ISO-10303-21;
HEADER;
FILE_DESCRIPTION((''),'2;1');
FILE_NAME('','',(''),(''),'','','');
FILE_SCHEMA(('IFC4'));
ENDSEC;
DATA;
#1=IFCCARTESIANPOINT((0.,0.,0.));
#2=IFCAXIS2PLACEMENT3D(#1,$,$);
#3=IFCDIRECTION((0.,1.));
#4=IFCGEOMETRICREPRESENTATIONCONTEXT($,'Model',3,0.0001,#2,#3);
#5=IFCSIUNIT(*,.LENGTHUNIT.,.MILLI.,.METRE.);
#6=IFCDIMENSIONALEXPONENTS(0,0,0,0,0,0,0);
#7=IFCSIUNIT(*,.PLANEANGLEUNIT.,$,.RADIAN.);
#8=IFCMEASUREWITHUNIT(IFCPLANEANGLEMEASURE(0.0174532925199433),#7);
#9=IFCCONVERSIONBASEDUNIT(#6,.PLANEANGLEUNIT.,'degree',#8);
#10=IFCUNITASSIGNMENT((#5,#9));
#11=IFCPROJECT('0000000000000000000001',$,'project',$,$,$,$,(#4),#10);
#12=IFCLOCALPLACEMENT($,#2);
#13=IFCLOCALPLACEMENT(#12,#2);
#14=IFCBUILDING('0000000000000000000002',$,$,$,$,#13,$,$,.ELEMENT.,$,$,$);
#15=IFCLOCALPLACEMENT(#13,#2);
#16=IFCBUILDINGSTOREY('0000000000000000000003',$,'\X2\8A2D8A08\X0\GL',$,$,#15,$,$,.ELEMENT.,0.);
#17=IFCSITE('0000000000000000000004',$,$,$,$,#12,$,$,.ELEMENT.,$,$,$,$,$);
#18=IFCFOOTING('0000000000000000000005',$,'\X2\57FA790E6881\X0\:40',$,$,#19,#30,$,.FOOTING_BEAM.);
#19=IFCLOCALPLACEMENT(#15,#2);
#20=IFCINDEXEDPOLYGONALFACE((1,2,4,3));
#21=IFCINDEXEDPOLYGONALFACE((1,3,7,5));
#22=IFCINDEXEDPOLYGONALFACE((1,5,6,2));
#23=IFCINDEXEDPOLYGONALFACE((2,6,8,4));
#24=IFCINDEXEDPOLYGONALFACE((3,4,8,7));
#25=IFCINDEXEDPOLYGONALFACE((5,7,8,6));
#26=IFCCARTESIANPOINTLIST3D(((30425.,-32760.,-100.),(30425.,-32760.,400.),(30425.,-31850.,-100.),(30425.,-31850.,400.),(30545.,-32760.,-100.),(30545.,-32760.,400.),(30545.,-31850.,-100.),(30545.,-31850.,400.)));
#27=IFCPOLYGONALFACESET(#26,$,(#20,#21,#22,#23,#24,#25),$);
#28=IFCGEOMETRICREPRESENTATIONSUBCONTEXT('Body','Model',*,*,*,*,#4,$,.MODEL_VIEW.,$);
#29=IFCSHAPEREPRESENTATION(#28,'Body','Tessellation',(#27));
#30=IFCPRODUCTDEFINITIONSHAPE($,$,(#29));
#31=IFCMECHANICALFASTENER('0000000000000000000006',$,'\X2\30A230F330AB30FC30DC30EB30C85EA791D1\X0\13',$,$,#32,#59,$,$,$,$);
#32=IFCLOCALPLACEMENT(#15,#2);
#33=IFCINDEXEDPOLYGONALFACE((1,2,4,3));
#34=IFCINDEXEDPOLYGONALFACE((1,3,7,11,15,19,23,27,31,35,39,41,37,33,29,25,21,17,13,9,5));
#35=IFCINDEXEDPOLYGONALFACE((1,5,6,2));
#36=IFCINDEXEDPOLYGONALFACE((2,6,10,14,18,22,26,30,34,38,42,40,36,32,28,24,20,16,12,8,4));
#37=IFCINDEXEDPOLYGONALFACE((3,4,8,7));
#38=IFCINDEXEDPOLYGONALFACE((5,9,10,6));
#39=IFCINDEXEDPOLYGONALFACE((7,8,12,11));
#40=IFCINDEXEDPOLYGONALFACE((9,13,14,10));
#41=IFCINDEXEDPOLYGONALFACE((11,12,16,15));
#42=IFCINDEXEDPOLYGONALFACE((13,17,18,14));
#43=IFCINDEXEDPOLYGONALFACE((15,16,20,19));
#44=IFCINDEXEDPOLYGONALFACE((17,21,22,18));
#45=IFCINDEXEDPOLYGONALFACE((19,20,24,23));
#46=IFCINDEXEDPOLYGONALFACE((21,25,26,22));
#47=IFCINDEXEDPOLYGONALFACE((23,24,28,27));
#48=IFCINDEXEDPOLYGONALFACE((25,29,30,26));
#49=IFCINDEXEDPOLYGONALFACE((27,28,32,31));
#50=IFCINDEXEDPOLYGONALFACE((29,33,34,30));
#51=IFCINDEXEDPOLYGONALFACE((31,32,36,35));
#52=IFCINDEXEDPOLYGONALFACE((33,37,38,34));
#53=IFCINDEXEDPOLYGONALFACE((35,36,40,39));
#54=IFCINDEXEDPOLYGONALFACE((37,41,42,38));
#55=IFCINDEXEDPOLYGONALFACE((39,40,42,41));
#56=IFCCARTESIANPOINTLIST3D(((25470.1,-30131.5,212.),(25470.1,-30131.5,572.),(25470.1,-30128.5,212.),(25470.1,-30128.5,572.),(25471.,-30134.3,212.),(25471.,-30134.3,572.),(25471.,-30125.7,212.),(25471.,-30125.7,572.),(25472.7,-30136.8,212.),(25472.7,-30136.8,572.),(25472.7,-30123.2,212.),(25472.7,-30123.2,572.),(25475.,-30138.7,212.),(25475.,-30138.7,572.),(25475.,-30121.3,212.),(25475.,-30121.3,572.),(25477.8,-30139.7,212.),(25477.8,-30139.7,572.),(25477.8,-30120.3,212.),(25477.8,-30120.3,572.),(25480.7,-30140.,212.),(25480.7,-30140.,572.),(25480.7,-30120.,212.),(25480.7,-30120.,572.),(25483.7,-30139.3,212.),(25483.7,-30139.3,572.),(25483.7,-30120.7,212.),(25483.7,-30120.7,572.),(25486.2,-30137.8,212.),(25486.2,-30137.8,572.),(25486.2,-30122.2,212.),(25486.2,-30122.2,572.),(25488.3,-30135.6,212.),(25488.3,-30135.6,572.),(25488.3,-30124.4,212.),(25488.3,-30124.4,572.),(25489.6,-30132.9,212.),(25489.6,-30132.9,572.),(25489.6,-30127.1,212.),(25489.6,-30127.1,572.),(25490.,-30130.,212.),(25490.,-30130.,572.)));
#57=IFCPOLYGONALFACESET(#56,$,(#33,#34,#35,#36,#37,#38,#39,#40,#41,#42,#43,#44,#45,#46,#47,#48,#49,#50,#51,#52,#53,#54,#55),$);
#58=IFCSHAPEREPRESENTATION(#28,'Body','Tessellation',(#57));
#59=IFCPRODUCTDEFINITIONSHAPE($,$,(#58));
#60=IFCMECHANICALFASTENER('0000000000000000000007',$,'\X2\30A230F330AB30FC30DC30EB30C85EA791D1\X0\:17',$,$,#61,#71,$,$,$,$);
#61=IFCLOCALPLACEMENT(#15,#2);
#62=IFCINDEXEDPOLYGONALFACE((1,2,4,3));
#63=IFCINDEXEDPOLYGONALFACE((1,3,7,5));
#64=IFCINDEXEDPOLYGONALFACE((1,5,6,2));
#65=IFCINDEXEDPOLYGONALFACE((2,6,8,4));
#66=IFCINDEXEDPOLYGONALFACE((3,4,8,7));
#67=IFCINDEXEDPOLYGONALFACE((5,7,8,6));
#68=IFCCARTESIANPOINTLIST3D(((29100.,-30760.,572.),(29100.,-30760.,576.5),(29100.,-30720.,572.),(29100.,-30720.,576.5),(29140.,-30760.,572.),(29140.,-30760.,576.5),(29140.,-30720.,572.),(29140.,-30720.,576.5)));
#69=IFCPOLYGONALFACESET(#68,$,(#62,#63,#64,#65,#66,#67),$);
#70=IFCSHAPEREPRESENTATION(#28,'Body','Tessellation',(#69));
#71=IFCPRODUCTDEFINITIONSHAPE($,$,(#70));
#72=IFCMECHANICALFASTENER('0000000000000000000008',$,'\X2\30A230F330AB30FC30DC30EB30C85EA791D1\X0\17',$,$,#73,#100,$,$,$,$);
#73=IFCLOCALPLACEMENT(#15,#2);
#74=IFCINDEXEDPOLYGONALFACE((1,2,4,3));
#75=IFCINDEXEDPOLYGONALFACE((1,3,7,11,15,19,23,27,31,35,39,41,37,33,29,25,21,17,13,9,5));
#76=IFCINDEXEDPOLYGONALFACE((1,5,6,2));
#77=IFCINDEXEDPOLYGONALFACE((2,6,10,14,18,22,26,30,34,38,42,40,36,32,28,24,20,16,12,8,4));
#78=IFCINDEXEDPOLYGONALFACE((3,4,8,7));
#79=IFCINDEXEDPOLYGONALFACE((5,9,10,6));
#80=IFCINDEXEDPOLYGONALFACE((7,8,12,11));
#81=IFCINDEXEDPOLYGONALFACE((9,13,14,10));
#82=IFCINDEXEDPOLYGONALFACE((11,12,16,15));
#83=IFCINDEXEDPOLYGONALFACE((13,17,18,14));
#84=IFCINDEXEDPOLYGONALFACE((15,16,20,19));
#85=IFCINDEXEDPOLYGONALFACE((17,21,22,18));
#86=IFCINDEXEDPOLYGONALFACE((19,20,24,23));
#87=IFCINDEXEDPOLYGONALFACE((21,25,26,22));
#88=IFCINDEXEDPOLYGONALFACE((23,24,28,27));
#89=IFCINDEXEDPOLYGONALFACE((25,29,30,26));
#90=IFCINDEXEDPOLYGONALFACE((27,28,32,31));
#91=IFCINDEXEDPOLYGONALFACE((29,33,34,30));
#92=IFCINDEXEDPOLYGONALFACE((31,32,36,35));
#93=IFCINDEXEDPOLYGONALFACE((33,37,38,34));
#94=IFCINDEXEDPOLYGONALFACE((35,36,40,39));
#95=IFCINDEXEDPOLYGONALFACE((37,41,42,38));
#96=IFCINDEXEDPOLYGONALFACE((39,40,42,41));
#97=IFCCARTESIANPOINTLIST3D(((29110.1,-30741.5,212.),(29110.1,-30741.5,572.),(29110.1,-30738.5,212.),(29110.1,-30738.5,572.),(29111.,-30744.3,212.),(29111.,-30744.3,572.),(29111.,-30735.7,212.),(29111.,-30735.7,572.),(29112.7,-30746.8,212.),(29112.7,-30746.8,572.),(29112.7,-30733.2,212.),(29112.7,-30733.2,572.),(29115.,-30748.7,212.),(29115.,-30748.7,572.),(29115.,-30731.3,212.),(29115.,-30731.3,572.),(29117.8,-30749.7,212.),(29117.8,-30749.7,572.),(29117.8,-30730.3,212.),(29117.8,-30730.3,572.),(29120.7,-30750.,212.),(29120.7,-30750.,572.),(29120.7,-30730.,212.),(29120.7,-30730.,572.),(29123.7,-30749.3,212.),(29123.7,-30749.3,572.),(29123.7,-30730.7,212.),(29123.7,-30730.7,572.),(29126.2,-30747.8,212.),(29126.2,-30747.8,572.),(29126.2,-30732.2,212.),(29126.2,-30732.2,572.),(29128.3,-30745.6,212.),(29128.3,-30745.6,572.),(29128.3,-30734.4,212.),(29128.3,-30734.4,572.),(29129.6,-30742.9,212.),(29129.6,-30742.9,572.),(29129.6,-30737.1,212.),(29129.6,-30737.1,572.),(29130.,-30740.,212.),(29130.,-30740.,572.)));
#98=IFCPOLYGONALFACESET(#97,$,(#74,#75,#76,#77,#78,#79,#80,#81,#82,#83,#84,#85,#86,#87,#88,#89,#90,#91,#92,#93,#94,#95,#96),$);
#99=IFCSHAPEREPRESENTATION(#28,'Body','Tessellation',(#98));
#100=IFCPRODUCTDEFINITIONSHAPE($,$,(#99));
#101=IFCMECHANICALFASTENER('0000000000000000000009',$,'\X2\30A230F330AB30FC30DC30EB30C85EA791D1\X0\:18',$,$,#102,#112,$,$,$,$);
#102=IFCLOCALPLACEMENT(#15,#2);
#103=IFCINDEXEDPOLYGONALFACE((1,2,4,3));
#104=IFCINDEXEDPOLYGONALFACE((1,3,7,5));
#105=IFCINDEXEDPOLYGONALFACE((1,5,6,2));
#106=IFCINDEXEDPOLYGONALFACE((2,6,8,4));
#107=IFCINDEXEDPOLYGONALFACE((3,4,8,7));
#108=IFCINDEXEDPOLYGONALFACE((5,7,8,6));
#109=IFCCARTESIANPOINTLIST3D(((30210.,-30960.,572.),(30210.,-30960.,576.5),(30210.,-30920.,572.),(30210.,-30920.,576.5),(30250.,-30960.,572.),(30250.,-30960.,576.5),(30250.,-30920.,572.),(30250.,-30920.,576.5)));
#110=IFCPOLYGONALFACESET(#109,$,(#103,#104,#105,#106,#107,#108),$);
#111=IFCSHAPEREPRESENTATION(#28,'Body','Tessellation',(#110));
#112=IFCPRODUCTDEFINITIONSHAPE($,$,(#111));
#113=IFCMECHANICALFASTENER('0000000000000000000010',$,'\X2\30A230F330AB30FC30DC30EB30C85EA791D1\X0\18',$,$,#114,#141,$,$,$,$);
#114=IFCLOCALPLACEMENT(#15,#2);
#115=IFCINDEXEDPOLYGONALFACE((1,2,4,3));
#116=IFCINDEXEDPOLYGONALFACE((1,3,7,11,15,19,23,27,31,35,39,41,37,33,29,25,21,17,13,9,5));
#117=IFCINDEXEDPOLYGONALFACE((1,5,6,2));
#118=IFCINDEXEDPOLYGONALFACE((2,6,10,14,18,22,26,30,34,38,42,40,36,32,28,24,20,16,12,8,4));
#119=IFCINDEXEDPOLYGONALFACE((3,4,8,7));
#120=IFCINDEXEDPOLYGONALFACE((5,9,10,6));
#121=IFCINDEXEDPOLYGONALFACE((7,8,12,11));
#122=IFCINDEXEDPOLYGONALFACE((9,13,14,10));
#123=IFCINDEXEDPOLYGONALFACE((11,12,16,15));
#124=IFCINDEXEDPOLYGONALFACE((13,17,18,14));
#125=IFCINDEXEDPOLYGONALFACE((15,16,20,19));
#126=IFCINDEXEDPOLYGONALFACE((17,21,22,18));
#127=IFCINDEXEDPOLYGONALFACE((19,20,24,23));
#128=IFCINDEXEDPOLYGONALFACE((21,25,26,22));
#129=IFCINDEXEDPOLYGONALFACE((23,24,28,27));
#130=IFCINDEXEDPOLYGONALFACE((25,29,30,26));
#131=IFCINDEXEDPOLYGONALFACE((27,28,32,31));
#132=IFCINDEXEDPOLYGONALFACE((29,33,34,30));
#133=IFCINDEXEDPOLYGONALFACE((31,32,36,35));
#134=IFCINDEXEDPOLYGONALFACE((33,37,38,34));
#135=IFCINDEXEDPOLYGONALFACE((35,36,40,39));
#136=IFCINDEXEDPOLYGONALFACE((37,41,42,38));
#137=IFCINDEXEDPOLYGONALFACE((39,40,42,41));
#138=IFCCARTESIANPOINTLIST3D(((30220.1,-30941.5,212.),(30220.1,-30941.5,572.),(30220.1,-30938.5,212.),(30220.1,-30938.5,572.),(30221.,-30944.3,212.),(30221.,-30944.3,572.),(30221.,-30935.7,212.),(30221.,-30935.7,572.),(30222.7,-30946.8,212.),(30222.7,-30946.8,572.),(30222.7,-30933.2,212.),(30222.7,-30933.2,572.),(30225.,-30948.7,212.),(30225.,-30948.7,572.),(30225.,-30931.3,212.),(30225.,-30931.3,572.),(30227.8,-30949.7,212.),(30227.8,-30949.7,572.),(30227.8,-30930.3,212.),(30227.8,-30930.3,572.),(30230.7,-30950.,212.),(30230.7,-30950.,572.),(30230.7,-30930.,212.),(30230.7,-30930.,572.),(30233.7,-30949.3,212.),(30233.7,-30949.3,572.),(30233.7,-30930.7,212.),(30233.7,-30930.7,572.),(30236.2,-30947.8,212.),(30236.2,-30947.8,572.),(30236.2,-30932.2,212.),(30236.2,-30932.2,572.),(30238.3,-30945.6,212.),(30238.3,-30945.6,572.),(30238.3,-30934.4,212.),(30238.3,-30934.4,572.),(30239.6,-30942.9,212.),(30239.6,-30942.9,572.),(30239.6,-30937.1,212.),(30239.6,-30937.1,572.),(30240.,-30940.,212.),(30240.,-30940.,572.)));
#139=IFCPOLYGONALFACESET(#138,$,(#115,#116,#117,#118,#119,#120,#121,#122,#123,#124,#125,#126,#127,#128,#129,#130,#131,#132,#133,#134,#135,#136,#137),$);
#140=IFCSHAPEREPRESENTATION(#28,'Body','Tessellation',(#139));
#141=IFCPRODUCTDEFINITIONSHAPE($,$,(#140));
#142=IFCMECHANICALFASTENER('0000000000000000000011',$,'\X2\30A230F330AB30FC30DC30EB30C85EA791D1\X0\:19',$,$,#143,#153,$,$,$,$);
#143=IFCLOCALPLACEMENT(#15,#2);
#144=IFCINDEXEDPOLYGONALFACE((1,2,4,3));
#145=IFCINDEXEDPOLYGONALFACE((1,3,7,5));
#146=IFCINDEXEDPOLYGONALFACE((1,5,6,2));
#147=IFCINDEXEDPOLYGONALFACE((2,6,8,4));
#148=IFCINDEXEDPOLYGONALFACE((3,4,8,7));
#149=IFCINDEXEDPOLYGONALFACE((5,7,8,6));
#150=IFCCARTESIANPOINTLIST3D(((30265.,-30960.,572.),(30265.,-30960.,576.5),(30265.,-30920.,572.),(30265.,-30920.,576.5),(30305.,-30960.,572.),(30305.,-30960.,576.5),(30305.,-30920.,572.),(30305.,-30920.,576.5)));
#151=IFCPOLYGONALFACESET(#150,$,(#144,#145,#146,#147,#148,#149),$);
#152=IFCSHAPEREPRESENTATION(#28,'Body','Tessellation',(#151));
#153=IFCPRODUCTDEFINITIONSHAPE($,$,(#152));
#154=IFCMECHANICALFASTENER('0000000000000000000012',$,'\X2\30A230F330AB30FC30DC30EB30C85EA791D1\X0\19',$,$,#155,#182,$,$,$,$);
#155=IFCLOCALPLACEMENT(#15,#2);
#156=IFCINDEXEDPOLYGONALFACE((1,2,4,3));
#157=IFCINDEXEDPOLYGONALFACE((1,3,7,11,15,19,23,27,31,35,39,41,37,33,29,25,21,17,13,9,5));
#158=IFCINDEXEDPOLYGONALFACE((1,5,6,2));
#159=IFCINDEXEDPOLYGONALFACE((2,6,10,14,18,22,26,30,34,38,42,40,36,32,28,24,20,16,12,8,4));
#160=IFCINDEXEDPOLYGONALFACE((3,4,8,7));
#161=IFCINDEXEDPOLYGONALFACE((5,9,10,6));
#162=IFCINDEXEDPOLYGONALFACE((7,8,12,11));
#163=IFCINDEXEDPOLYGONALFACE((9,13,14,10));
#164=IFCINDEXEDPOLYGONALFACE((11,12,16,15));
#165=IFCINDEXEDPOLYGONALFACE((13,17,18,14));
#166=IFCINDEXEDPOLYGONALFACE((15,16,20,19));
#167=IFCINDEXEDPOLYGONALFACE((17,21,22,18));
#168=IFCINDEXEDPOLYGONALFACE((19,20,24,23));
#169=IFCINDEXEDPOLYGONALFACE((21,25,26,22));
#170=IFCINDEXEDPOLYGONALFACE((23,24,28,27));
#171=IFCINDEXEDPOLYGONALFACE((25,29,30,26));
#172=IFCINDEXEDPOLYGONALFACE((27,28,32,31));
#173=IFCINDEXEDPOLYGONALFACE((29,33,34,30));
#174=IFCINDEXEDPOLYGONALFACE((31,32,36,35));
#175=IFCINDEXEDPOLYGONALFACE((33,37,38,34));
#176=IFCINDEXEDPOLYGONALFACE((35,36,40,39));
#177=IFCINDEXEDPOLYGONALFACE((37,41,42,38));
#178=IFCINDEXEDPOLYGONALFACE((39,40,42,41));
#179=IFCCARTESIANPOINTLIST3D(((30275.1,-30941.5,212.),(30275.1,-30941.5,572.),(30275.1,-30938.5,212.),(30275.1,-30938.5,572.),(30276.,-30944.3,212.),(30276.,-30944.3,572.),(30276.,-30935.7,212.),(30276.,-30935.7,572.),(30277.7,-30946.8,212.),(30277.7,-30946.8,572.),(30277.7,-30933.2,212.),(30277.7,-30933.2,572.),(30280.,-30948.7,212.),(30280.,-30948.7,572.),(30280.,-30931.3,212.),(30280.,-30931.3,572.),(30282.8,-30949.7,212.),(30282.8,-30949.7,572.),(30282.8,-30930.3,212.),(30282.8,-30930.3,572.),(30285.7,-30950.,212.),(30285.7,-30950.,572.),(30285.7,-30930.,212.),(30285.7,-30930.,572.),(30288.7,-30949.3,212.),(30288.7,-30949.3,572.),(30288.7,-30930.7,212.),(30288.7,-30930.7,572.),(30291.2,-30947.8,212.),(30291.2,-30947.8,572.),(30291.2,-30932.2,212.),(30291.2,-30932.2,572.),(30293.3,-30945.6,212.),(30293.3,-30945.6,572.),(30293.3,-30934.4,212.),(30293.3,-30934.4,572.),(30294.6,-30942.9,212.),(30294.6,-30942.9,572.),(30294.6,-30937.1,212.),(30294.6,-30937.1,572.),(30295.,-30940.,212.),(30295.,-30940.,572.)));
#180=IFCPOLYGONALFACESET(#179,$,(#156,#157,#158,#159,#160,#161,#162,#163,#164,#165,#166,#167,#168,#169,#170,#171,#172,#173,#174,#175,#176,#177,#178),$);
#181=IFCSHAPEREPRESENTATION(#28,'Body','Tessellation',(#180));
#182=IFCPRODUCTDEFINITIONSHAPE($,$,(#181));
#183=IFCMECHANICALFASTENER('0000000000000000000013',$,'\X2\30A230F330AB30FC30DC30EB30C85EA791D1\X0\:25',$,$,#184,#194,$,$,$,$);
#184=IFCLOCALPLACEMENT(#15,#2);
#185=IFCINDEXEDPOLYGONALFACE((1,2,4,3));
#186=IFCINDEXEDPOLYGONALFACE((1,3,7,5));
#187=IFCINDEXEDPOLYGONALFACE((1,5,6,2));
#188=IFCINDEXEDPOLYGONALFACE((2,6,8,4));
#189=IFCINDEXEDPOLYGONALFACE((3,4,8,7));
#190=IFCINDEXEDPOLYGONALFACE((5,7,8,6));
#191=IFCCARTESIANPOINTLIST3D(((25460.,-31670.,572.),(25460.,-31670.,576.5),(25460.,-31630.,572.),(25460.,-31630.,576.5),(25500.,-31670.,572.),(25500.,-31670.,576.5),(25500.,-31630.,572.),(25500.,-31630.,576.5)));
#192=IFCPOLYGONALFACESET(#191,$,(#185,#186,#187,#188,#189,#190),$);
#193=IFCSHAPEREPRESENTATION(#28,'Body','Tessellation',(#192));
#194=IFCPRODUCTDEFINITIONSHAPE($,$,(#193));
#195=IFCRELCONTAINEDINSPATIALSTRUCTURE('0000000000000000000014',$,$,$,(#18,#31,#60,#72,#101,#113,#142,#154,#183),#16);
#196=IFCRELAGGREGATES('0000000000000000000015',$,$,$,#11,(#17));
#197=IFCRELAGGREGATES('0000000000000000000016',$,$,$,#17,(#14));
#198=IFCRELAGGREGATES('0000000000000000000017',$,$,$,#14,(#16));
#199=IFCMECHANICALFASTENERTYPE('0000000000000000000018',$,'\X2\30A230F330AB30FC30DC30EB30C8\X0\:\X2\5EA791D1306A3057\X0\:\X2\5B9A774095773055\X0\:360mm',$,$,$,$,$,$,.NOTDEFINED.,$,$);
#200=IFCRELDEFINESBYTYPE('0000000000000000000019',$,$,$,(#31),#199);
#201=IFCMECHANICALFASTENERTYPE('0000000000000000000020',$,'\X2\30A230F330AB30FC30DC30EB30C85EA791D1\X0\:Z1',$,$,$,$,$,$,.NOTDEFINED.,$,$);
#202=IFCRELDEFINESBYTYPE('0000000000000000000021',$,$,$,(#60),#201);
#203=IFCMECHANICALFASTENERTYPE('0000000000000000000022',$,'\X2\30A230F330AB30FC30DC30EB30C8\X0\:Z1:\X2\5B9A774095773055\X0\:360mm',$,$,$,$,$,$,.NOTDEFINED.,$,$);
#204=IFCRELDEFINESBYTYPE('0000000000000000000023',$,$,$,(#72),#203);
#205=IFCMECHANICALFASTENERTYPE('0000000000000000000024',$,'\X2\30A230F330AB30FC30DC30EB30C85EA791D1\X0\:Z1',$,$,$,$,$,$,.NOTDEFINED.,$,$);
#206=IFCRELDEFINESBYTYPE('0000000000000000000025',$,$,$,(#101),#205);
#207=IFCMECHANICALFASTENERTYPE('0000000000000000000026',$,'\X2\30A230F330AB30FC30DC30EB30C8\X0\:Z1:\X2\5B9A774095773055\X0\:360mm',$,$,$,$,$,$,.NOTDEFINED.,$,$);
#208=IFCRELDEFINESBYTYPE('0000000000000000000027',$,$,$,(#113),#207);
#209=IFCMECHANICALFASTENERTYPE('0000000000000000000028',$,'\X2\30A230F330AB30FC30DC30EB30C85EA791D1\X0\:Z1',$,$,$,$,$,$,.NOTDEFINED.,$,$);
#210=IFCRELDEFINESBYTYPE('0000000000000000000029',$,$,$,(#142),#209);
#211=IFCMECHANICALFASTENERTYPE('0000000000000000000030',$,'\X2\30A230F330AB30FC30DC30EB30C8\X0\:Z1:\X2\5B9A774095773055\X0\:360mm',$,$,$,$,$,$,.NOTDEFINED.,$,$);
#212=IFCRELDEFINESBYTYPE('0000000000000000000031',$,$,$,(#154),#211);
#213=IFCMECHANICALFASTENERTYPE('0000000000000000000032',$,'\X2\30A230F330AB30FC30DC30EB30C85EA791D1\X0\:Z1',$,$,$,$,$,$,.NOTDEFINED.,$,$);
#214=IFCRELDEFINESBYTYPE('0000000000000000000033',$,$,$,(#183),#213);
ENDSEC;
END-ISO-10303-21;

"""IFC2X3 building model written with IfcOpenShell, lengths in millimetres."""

from ifc_helpers import new_model, entity, si_unit, converted_unit, direction, frame, origin, origin_with_axes, origin_2d, place, context, subcontext, project, spatial, rectangle, circle, extrude, type_object, element, save


model = new_model("IFC2X3")

# Units and contexts
model_context = context("Model", 3, precision=0.0001, world=origin(), true_north=direction((0.0, 1.0)))
body_context = subcontext(model_context, "Body", "Model", "MODEL_VIEW")
ifc_project = project(units=[si_unit("LENGTHUNIT", "METRE", prefix="MILLI"), converted_unit("PLANEANGLEUNIT", "degree", entity("IfcPlaneAngleMeasure", 0.0174532925199433), si_unit("PLANEANGLEUNIT", "RADIAN"), dimensions=[0, 0, 0, 0, 0, 0, 0])], contexts=[model_context])

# Site, building, storey
site_placement = place(None, origin())
site = spatial("IfcSite", under=ifc_project, at=site_placement, CompositionType="ELEMENT")
building_placement = place(site_placement, origin())
building = spatial("IfcBuilding", under=site, at=building_placement, CompositionType="ELEMENT")
storey_placement = place(building_placement, origin())
storey = spatial("IfcBuildingStorey", under=building, at=storey_placement, Name="設計GL", CompositionType="ELEMENT", Elevation=0.0)

# Footing
for number, where, z_axis, x_axis, name in (
    (1, (30485.0, -31850.0, 150.0), (0.0, -1.0, 0.0), (1.0, 0.0, 0.0), "基礎梁:40"),
):
    element("IfcFooting", number, at=place(storey_placement, frame(where, z_axis=z_axis, x_axis=x_axis)), inside=storey, Name=name, PredefinedType="FOOTING_BEAM", context=body_context, shape_type="SolidModel", body=[
        extrude(rectangle(XDim=120.0, YDim=500.0, at=origin_2d()), origin_with_axes(), (0.0, 0.0, 1.0), 910.0),
    ])

# Mechanical fasteners
mechanical_fastener_type_1 = type_object("IfcMechanicalFastenerType", Name="アンカーボルト:座金なし:定着長さ:360mm")
mechanical_fastener_1_placement = place(storey_placement, frame((25480.0, -30130.0, 212.0)))
element("IfcMechanicalFastener", 2, at=mechanical_fastener_1_placement, inside=storey, type_object=mechanical_fastener_type_1, Name="アンカーボルト座金13", context=body_context, shape_type="SweptSolid", body=[
    extrude(circle(Radius=10.0, at=origin_2d()), origin_with_axes(), (0.0, 0.0, 1.0), 360.0),
])
mechanical_fastener_type_2 = type_object("IfcMechanicalFastenerType", Name="アンカーボルト座金:Z1")
mechanical_fastener_2_placement = place(storey_placement, frame((29120.0, -30740.0, 572.0)))
element("IfcMechanicalFastener", 3, at=mechanical_fastener_2_placement, inside=storey, type_object=mechanical_fastener_type_2, Name="アンカーボルト座金:17", context=body_context, shape_type="SweptSolid", body=[
    extrude(rectangle(XDim=40.0, YDim=40.0, at=origin_2d()), origin_with_axes(), (0.0, 0.0, 1.0), 4.5),
])
mechanical_fastener_type_3 = type_object("IfcMechanicalFastenerType", Name="アンカーボルト:Z1:定着長さ:360mm")
mechanical_fastener_3_placement = place(storey_placement, frame((29120.0, -30740.0, 212.0)))
element("IfcMechanicalFastener", 4, at=mechanical_fastener_3_placement, inside=storey, type_object=mechanical_fastener_type_3, Name="アンカーボルト座金17", context=body_context, shape_type="SweptSolid", body=[
    extrude(circle(Radius=10.0, at=origin_2d()), origin_with_axes(), (0.0, 0.0, 1.0), 360.0),
])
mechanical_fastener_type_4 = type_object("IfcMechanicalFastenerType", Name="アンカーボルト座金:Z1")
mechanical_fastener_4_placement = place(storey_placement, frame((30230.0, -30940.0, 572.0)))
element("IfcMechanicalFastener", 5, at=mechanical_fastener_4_placement, inside=storey, type_object=mechanical_fastener_type_4, Name="アンカーボルト座金:18", context=body_context, shape_type="SweptSolid", body=[
    extrude(rectangle(XDim=40.0, YDim=40.0, at=origin_2d()), origin_with_axes(), (0.0, 0.0, 1.0), 4.5),
])
mechanical_fastener_type_5 = type_object("IfcMechanicalFastenerType", Name="アンカーボルト:Z1:定着長さ:360mm")
mechanical_fastener_5_placement = place(storey_placement, frame((30230.0, -30940.0, 212.0)))
element("IfcMechanicalFastener", 6, at=mechanical_fastener_5_placement, inside=storey, type_object=mechanical_fastener_type_5, Name="アンカーボルト座金18", context=body_context, shape_type="SweptSolid", body=[
    extrude(circle(Radius=10.0, at=origin_2d()), origin_with_axes(), (0.0, 0.0, 1.0), 360.0),
])
mechanical_fastener_type_6 = type_object("IfcMechanicalFastenerType", Name="アンカーボルト座金:Z1")
mechanical_fastener_6_placement = place(storey_placement, frame((30285.0, -30940.0, 572.0)))
element("IfcMechanicalFastener", 7, at=mechanical_fastener_6_placement, inside=storey, type_object=mechanical_fastener_type_6, Name="アンカーボルト座金:19", context=body_context, shape_type="SweptSolid", body=[
    extrude(rectangle(XDim=40.0, YDim=40.0, at=origin_2d()), origin_with_axes(), (0.0, 0.0, 1.0), 4.5),
])
mechanical_fastener_type_7 = type_object("IfcMechanicalFastenerType", Name="アンカーボルト:Z1:定着長さ:360mm")
mechanical_fastener_7_placement = place(storey_placement, frame((30285.0, -30940.0, 212.0)))
element("IfcMechanicalFastener", 8, at=mechanical_fastener_7_placement, inside=storey, type_object=mechanical_fastener_type_7, Name="アンカーボルト座金19", context=body_context, shape_type="SweptSolid", body=[
    extrude(circle(Radius=10.0, at=origin_2d()), origin_with_axes(), (0.0, 0.0, 1.0), 360.0),
])
mechanical_fastener_type_8 = type_object("IfcMechanicalFastenerType", Name="アンカーボルト座金:Z1")
mechanical_fastener_8_placement = place(storey_placement, frame((25480.0, -31650.0, 572.0)))
element("IfcMechanicalFastener", 9, at=mechanical_fastener_8_placement, inside=storey, type_object=mechanical_fastener_type_8, Name="アンカーボルト座金:25", context=body_context, shape_type="SweptSolid", body=[
    extrude(rectangle(XDim=40.0, YDim=40.0, at=origin_2d()), origin_with_axes(), (0.0, 0.0, 1.0), 4.5),
])

save(model, "model.ifc")
